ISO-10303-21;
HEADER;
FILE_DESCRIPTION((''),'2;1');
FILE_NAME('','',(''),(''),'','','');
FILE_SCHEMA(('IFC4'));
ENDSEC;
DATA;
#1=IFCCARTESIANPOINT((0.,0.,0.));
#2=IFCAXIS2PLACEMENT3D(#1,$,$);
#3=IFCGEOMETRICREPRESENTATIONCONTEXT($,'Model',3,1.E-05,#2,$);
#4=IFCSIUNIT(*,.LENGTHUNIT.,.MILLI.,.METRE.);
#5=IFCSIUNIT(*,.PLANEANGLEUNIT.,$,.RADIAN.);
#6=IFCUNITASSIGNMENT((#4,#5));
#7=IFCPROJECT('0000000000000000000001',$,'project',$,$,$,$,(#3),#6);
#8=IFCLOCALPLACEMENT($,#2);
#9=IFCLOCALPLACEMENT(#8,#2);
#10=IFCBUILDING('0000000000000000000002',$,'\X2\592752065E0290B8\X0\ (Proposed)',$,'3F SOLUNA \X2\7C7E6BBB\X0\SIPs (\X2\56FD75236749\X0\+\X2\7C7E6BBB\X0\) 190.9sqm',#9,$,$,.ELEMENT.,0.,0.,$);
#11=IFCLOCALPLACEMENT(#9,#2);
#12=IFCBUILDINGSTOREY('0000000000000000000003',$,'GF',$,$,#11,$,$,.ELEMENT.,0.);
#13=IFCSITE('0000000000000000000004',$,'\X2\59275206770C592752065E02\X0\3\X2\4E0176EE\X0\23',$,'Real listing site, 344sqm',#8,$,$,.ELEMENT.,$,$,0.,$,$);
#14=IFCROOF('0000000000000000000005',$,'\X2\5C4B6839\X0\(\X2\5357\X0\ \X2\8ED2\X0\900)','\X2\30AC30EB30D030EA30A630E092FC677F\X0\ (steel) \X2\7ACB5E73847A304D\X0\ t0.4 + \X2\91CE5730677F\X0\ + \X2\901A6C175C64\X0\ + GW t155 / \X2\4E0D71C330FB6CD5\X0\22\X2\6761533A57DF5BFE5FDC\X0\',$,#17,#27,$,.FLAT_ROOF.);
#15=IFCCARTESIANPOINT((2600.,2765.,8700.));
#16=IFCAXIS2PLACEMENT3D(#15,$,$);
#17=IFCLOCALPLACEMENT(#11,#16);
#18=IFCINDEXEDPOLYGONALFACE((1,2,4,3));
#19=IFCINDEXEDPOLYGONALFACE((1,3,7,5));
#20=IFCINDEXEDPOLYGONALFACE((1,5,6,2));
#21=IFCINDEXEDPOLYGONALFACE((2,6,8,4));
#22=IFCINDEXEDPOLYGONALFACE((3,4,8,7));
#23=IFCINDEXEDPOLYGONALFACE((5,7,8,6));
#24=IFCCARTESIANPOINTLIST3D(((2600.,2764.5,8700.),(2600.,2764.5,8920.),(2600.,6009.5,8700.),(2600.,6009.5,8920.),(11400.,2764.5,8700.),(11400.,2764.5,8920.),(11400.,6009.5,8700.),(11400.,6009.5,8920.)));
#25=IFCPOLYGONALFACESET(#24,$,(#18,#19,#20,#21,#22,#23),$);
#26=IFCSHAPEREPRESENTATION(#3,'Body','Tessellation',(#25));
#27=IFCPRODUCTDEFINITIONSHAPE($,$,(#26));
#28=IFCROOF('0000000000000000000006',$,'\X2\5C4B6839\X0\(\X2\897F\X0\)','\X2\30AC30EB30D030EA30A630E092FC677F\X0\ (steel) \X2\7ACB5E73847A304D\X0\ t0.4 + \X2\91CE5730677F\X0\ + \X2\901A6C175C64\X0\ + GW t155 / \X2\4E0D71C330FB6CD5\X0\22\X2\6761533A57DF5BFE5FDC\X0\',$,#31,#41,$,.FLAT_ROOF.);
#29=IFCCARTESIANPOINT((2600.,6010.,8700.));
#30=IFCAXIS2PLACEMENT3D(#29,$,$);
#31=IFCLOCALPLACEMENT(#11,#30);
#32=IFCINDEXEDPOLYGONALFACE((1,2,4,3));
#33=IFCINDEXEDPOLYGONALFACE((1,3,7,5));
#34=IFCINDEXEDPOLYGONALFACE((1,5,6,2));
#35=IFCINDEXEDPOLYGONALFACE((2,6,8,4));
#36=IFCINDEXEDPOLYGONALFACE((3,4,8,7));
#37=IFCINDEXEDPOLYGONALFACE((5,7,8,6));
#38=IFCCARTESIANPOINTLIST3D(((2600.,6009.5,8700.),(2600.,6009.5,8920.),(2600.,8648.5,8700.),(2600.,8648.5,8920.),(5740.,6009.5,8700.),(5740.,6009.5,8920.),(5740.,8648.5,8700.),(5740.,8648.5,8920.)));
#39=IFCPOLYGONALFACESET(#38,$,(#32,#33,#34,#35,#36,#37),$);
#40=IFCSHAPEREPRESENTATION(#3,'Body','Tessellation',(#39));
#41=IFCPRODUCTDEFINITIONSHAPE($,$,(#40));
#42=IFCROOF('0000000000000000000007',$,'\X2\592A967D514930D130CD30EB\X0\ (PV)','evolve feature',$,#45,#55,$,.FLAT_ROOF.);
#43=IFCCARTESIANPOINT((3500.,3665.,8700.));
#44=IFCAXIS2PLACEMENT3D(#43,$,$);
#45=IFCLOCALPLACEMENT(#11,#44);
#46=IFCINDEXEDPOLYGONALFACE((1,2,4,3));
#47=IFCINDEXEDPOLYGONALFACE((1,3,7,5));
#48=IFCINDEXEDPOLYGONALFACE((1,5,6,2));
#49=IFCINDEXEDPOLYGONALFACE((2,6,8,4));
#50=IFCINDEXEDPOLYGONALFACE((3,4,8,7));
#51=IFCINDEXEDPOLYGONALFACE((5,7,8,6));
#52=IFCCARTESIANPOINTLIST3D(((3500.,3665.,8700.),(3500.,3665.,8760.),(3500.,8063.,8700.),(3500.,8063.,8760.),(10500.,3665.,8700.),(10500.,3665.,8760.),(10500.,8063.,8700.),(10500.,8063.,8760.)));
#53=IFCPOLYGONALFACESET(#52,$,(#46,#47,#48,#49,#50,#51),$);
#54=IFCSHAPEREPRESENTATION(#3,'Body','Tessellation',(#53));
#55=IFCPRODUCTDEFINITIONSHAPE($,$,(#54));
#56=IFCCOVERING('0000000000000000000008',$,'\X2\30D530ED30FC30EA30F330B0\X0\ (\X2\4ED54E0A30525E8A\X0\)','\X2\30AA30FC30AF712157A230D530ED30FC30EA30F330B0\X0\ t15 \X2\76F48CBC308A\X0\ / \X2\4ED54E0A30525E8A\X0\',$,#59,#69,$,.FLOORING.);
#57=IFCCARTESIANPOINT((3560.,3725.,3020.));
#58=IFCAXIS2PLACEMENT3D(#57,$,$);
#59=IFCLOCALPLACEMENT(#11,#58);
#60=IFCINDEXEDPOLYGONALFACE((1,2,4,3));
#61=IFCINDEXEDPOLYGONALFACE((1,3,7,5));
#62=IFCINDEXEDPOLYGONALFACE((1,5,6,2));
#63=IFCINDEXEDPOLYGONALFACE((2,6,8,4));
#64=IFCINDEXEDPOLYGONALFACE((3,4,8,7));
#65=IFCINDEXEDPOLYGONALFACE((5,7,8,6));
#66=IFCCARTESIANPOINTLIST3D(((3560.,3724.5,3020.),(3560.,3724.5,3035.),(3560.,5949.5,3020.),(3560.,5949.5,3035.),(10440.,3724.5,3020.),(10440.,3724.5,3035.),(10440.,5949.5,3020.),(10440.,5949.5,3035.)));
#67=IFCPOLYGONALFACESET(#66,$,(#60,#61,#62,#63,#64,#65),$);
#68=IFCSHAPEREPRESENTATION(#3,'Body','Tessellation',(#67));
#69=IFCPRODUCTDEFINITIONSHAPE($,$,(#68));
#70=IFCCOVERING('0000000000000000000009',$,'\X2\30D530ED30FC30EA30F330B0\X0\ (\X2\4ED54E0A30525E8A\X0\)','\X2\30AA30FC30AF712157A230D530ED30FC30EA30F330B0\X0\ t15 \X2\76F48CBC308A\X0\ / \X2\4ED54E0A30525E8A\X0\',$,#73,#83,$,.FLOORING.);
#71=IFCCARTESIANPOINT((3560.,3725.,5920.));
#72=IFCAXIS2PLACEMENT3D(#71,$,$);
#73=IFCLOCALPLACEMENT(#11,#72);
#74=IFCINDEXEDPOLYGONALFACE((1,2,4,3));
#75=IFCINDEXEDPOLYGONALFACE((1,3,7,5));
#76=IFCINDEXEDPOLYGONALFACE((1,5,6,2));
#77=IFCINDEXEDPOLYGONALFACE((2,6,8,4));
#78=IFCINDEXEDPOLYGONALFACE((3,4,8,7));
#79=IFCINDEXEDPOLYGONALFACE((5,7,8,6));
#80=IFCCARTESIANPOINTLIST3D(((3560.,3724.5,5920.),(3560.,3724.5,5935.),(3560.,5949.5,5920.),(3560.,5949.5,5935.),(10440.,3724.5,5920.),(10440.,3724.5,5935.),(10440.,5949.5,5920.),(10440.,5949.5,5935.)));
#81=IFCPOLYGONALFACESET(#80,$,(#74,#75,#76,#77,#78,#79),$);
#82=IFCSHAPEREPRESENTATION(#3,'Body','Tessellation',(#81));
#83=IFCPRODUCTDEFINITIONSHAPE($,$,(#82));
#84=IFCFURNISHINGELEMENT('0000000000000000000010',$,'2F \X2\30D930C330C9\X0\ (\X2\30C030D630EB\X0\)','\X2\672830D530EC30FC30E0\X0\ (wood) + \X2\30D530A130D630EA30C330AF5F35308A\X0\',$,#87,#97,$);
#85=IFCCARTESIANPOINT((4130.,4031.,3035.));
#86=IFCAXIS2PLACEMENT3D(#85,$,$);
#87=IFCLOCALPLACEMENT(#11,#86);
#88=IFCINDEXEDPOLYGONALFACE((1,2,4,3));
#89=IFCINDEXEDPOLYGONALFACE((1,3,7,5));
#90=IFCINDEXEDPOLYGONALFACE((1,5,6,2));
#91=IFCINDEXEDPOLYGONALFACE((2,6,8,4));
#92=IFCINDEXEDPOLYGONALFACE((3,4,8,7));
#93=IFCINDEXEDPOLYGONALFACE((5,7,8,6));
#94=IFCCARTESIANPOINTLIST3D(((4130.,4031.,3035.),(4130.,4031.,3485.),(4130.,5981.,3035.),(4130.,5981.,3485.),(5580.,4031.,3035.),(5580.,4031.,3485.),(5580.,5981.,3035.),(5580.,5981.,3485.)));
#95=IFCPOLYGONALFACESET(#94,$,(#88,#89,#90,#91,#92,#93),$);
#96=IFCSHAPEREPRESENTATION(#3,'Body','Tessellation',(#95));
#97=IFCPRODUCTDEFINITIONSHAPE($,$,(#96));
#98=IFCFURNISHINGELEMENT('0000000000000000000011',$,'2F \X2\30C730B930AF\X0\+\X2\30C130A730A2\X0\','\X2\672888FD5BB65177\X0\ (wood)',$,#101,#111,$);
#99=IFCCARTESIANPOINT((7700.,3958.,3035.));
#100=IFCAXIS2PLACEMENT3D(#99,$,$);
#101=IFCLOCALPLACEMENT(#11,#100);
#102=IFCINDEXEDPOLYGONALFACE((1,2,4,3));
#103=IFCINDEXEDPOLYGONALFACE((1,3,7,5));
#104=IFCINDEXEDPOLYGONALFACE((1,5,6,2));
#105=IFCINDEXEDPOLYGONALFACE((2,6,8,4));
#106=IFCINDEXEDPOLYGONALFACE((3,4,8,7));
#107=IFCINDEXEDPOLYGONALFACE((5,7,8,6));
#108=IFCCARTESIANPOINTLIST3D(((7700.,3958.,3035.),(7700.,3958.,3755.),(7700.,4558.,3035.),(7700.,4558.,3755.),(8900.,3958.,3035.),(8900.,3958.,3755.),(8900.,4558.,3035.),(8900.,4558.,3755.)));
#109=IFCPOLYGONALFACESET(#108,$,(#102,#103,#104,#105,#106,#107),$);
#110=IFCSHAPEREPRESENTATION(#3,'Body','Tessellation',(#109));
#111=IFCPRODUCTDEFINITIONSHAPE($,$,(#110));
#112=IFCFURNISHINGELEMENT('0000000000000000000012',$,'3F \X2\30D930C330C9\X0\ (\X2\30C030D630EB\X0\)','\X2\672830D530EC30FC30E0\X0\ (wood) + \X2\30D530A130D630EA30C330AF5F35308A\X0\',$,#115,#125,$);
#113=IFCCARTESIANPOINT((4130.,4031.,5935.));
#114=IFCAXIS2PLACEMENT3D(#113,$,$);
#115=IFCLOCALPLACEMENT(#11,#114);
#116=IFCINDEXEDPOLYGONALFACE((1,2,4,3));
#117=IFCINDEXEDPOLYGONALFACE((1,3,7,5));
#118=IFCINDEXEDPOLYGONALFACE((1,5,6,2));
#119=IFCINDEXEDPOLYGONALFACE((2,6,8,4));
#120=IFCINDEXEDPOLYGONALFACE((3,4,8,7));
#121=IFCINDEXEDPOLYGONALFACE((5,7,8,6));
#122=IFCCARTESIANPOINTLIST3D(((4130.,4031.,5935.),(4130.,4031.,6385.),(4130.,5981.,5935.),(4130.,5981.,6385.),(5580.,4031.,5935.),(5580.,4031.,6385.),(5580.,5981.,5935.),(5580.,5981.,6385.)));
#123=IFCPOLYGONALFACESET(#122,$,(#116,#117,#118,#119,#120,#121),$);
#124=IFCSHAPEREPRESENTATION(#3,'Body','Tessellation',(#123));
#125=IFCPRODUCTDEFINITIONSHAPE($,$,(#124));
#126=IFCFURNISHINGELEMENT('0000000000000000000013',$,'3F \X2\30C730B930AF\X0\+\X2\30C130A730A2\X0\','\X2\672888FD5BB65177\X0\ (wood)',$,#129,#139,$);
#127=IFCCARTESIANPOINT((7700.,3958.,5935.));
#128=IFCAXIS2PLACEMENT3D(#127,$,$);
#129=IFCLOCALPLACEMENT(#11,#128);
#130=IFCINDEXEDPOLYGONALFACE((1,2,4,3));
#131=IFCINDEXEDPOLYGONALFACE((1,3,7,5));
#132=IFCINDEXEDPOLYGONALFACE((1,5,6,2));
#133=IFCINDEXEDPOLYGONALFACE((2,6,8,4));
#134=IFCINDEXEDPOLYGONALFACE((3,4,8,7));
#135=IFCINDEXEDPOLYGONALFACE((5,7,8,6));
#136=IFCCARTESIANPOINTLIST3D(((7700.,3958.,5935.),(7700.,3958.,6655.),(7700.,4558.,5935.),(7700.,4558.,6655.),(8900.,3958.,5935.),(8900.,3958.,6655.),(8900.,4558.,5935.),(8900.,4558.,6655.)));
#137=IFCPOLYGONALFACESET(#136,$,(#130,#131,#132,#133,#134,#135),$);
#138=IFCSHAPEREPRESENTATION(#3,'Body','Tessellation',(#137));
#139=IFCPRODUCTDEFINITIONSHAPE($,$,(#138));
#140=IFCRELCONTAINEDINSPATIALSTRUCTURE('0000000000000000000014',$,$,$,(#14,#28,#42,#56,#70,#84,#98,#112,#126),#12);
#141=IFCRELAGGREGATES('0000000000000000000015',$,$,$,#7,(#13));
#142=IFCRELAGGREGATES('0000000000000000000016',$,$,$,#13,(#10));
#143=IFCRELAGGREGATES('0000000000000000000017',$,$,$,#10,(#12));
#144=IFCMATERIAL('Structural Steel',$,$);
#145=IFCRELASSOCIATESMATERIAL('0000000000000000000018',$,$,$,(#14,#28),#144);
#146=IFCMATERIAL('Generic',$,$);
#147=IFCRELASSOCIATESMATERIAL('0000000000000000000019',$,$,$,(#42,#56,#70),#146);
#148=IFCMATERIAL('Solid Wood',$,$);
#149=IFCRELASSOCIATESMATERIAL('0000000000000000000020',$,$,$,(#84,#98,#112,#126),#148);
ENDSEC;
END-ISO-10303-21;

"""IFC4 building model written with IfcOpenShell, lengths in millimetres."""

from ifc_helpers import new_model, si_unit, frame, frame_2d, origin, place, context, project, spatial, rectangle, extrude, material, element, save


model = new_model("IFC4")

# Units and contexts
model_context = context("Model", 3, precision=1e-05, world=origin())
ifc_project = project(units=[si_unit("LENGTHUNIT", "METRE", prefix="MILLI"), si_unit("PLANEANGLEUNIT", "RADIAN")], contexts=[model_context])

# Site, building, storey
site_placement = place(None, origin())
site = spatial("IfcSite", under=ifc_project, at=site_placement, Name="大分県大分市3丁目23", ObjectType="Real listing site, 344sqm", CompositionType="ELEMENT", RefElevation=0.0)
building_placement = place(site_placement, origin())
building = spatial("IfcBuilding", under=site, at=building_placement, Name="大分市邸 (Proposed)", ObjectType="3F SOLUNA 籾殻SIPs (国産杉+籾殻) 190.9sqm", CompositionType="ELEMENT", ElevationOfRefHeight=0.0, ElevationOfTerrain=0.0)
storey_placement = place(building_placement, origin())
storey = spatial("IfcBuildingStorey", under=building, at=storey_placement, Name="GF", CompositionType="ELEMENT", Elevation=0.0)

# Shared definitions
ifc_material_1 = material(Name="Solid Wood")

# Roofs
ifc_material_2 = material(Name="Structural Steel")
roof_1_placement = place(storey_placement, frame((2600.0, 2765.0, 8700.0)))
element("IfcRoof", 1, at=roof_1_placement, inside=storey, material=ifc_material_2, Name="屋根(南 軒900)", Description="ガルバリウム鋼板 (steel) 立平葺き t0.4 + 野地板 + 通気層 + GW t155 / 不燃・法22条区域対応", PredefinedType="FLAT_ROOF", context=model_context, shape_type="SweptSolid", body=[
    extrude(rectangle(XDim=8800.0, YDim=3245.0, at=frame_2d((4400.0, 1622.0))), frame((2600.0, 2765.0, 8700.0)), (0.0, 0.0, 1.0), 220.0),
])
roof_2_placement = place(storey_placement, frame((2600.0, 6010.0, 8700.0)))
element("IfcRoof", 2, at=roof_2_placement, inside=storey, material=ifc_material_2, Name="屋根(西)", Description="ガルバリウム鋼板 (steel) 立平葺き t0.4 + 野地板 + 通気層 + GW t155 / 不燃・法22条区域対応", PredefinedType="FLAT_ROOF", context=model_context, shape_type="SweptSolid", body=[
    extrude(rectangle(XDim=3140.0, YDim=2639.0, at=frame_2d((1570.0, 1319.0))), frame((2600.0, 6010.0, 8700.0)), (0.0, 0.0, 1.0), 220.0),
])
ifc_material_3 = material(Name="Generic")
roof_3_placement = place(storey_placement, frame((3500.0, 3665.0, 8700.0)))
element("IfcRoof", 3, at=roof_3_placement, inside=storey, material=ifc_material_3, Name="太陽光パネル (PV)", Description="evolve feature", PredefinedType="FLAT_ROOF", context=model_context, shape_type="SweptSolid", body=[
    extrude(rectangle(XDim=7000.0, YDim=4398.0, at=frame_2d((3500.0, 2199.0))), frame((3500.0, 3665.0, 8700.0)), (0.0, 0.0, 1.0), 60.0),
])

# Coverings
covering_1_placement = place(storey_placement, frame((3560.0, 3725.0, 3020.0)))
element("IfcCovering", 4, at=covering_1_placement, inside=storey, material=ifc_material_3, Name="フローリング (仕上げ床)", Description="オーク無垢フローリング t15 直貼り / 仕上げ床", PredefinedType="FLOORING", context=model_context, shape_type="SweptSolid", body=[
    extrude(rectangle(XDim=6880.0, YDim=2225.0, at=frame_2d((3440.0, 1112.0))), frame((3560.0, 3725.0, 3020.0)), (0.0, 0.0, 1.0), 15.0),
])
covering_2_placement = place(storey_placement, frame((3560.0, 3725.0, 5920.0)))
element("IfcCovering", 5, at=covering_2_placement, inside=storey, material=ifc_material_3, Name="フローリング (仕上げ床)", Description="オーク無垢フローリング t15 直貼り / 仕上げ床", PredefinedType="FLOORING", context=model_context, shape_type="SweptSolid", body=[
    extrude(rectangle(XDim=6880.0, YDim=2225.0, at=frame_2d((3440.0, 1112.0))), frame((3560.0, 3725.0, 5920.0)), (0.0, 0.0, 1.0), 15.0),
])

# Furnishing elements
furnishing_1_placement = place(storey_placement, frame((4130.0, 4031.0, 3035.0)))
element("IfcFurnishingElement", 6, at=furnishing_1_placement, inside=storey, material=ifc_material_1, Name="2F ベッド (ダブル)", Description="木フレーム (wood) + ファブリック張り", context=model_context, shape_type="SweptSolid", body=[
    extrude(rectangle(XDim=1450.0, YDim=1950.0, at=frame_2d((725.0, 975.0))), frame((4130.0, 4031.0, 3035.0)), (0.0, 0.0, 1.0), 450.0),
])
furnishing_2_placement = place(storey_placement, frame((7700.0, 3958.0, 3035.0)))
element("IfcFurnishingElement", 7, at=furnishing_2_placement, inside=storey, material=ifc_material_1, Name="2F デスク+チェア", Description="木製家具 (wood)", context=model_context, shape_type="SweptSolid", body=[
    extrude(rectangle(XDim=1200.0, YDim=600.0, at=frame_2d((600.0, 300.0))), frame((7700.0, 3958.0, 3035.0)), (0.0, 0.0, 1.0), 720.0),
])
furnishing_3_placement = place(storey_placement, frame((4130.0, 4031.0, 5935.0)))
element("IfcFurnishingElement", 8, at=furnishing_3_placement, inside=storey, material=ifc_material_1, Name="3F ベッド (ダブル)", Description="木フレーム (wood) + ファブリック張り", context=model_context, shape_type="SweptSolid", body=[
    extrude(rectangle(XDim=1450.0, YDim=1950.0, at=frame_2d((725.0, 975.0))), frame((4130.0, 4031.0, 5935.0)), (0.0, 0.0, 1.0), 450.0),
])
furnishing_4_placement = place(storey_placement, frame((7700.0, 3958.0, 5935.0)))
element("IfcFurnishingElement", 9, at=furnishing_4_placement, inside=storey, material=ifc_material_1, Name="3F デスク+チェア", Description="木製家具 (wood)", context=model_context, shape_type="SweptSolid", body=[
    extrude(rectangle(XDim=1200.0, YDim=600.0, at=frame_2d((600.0, 300.0))), frame((7700.0, 3958.0, 5935.0)), (0.0, 0.0, 1.0), 720.0),
])

save(model, "model.ifc")
